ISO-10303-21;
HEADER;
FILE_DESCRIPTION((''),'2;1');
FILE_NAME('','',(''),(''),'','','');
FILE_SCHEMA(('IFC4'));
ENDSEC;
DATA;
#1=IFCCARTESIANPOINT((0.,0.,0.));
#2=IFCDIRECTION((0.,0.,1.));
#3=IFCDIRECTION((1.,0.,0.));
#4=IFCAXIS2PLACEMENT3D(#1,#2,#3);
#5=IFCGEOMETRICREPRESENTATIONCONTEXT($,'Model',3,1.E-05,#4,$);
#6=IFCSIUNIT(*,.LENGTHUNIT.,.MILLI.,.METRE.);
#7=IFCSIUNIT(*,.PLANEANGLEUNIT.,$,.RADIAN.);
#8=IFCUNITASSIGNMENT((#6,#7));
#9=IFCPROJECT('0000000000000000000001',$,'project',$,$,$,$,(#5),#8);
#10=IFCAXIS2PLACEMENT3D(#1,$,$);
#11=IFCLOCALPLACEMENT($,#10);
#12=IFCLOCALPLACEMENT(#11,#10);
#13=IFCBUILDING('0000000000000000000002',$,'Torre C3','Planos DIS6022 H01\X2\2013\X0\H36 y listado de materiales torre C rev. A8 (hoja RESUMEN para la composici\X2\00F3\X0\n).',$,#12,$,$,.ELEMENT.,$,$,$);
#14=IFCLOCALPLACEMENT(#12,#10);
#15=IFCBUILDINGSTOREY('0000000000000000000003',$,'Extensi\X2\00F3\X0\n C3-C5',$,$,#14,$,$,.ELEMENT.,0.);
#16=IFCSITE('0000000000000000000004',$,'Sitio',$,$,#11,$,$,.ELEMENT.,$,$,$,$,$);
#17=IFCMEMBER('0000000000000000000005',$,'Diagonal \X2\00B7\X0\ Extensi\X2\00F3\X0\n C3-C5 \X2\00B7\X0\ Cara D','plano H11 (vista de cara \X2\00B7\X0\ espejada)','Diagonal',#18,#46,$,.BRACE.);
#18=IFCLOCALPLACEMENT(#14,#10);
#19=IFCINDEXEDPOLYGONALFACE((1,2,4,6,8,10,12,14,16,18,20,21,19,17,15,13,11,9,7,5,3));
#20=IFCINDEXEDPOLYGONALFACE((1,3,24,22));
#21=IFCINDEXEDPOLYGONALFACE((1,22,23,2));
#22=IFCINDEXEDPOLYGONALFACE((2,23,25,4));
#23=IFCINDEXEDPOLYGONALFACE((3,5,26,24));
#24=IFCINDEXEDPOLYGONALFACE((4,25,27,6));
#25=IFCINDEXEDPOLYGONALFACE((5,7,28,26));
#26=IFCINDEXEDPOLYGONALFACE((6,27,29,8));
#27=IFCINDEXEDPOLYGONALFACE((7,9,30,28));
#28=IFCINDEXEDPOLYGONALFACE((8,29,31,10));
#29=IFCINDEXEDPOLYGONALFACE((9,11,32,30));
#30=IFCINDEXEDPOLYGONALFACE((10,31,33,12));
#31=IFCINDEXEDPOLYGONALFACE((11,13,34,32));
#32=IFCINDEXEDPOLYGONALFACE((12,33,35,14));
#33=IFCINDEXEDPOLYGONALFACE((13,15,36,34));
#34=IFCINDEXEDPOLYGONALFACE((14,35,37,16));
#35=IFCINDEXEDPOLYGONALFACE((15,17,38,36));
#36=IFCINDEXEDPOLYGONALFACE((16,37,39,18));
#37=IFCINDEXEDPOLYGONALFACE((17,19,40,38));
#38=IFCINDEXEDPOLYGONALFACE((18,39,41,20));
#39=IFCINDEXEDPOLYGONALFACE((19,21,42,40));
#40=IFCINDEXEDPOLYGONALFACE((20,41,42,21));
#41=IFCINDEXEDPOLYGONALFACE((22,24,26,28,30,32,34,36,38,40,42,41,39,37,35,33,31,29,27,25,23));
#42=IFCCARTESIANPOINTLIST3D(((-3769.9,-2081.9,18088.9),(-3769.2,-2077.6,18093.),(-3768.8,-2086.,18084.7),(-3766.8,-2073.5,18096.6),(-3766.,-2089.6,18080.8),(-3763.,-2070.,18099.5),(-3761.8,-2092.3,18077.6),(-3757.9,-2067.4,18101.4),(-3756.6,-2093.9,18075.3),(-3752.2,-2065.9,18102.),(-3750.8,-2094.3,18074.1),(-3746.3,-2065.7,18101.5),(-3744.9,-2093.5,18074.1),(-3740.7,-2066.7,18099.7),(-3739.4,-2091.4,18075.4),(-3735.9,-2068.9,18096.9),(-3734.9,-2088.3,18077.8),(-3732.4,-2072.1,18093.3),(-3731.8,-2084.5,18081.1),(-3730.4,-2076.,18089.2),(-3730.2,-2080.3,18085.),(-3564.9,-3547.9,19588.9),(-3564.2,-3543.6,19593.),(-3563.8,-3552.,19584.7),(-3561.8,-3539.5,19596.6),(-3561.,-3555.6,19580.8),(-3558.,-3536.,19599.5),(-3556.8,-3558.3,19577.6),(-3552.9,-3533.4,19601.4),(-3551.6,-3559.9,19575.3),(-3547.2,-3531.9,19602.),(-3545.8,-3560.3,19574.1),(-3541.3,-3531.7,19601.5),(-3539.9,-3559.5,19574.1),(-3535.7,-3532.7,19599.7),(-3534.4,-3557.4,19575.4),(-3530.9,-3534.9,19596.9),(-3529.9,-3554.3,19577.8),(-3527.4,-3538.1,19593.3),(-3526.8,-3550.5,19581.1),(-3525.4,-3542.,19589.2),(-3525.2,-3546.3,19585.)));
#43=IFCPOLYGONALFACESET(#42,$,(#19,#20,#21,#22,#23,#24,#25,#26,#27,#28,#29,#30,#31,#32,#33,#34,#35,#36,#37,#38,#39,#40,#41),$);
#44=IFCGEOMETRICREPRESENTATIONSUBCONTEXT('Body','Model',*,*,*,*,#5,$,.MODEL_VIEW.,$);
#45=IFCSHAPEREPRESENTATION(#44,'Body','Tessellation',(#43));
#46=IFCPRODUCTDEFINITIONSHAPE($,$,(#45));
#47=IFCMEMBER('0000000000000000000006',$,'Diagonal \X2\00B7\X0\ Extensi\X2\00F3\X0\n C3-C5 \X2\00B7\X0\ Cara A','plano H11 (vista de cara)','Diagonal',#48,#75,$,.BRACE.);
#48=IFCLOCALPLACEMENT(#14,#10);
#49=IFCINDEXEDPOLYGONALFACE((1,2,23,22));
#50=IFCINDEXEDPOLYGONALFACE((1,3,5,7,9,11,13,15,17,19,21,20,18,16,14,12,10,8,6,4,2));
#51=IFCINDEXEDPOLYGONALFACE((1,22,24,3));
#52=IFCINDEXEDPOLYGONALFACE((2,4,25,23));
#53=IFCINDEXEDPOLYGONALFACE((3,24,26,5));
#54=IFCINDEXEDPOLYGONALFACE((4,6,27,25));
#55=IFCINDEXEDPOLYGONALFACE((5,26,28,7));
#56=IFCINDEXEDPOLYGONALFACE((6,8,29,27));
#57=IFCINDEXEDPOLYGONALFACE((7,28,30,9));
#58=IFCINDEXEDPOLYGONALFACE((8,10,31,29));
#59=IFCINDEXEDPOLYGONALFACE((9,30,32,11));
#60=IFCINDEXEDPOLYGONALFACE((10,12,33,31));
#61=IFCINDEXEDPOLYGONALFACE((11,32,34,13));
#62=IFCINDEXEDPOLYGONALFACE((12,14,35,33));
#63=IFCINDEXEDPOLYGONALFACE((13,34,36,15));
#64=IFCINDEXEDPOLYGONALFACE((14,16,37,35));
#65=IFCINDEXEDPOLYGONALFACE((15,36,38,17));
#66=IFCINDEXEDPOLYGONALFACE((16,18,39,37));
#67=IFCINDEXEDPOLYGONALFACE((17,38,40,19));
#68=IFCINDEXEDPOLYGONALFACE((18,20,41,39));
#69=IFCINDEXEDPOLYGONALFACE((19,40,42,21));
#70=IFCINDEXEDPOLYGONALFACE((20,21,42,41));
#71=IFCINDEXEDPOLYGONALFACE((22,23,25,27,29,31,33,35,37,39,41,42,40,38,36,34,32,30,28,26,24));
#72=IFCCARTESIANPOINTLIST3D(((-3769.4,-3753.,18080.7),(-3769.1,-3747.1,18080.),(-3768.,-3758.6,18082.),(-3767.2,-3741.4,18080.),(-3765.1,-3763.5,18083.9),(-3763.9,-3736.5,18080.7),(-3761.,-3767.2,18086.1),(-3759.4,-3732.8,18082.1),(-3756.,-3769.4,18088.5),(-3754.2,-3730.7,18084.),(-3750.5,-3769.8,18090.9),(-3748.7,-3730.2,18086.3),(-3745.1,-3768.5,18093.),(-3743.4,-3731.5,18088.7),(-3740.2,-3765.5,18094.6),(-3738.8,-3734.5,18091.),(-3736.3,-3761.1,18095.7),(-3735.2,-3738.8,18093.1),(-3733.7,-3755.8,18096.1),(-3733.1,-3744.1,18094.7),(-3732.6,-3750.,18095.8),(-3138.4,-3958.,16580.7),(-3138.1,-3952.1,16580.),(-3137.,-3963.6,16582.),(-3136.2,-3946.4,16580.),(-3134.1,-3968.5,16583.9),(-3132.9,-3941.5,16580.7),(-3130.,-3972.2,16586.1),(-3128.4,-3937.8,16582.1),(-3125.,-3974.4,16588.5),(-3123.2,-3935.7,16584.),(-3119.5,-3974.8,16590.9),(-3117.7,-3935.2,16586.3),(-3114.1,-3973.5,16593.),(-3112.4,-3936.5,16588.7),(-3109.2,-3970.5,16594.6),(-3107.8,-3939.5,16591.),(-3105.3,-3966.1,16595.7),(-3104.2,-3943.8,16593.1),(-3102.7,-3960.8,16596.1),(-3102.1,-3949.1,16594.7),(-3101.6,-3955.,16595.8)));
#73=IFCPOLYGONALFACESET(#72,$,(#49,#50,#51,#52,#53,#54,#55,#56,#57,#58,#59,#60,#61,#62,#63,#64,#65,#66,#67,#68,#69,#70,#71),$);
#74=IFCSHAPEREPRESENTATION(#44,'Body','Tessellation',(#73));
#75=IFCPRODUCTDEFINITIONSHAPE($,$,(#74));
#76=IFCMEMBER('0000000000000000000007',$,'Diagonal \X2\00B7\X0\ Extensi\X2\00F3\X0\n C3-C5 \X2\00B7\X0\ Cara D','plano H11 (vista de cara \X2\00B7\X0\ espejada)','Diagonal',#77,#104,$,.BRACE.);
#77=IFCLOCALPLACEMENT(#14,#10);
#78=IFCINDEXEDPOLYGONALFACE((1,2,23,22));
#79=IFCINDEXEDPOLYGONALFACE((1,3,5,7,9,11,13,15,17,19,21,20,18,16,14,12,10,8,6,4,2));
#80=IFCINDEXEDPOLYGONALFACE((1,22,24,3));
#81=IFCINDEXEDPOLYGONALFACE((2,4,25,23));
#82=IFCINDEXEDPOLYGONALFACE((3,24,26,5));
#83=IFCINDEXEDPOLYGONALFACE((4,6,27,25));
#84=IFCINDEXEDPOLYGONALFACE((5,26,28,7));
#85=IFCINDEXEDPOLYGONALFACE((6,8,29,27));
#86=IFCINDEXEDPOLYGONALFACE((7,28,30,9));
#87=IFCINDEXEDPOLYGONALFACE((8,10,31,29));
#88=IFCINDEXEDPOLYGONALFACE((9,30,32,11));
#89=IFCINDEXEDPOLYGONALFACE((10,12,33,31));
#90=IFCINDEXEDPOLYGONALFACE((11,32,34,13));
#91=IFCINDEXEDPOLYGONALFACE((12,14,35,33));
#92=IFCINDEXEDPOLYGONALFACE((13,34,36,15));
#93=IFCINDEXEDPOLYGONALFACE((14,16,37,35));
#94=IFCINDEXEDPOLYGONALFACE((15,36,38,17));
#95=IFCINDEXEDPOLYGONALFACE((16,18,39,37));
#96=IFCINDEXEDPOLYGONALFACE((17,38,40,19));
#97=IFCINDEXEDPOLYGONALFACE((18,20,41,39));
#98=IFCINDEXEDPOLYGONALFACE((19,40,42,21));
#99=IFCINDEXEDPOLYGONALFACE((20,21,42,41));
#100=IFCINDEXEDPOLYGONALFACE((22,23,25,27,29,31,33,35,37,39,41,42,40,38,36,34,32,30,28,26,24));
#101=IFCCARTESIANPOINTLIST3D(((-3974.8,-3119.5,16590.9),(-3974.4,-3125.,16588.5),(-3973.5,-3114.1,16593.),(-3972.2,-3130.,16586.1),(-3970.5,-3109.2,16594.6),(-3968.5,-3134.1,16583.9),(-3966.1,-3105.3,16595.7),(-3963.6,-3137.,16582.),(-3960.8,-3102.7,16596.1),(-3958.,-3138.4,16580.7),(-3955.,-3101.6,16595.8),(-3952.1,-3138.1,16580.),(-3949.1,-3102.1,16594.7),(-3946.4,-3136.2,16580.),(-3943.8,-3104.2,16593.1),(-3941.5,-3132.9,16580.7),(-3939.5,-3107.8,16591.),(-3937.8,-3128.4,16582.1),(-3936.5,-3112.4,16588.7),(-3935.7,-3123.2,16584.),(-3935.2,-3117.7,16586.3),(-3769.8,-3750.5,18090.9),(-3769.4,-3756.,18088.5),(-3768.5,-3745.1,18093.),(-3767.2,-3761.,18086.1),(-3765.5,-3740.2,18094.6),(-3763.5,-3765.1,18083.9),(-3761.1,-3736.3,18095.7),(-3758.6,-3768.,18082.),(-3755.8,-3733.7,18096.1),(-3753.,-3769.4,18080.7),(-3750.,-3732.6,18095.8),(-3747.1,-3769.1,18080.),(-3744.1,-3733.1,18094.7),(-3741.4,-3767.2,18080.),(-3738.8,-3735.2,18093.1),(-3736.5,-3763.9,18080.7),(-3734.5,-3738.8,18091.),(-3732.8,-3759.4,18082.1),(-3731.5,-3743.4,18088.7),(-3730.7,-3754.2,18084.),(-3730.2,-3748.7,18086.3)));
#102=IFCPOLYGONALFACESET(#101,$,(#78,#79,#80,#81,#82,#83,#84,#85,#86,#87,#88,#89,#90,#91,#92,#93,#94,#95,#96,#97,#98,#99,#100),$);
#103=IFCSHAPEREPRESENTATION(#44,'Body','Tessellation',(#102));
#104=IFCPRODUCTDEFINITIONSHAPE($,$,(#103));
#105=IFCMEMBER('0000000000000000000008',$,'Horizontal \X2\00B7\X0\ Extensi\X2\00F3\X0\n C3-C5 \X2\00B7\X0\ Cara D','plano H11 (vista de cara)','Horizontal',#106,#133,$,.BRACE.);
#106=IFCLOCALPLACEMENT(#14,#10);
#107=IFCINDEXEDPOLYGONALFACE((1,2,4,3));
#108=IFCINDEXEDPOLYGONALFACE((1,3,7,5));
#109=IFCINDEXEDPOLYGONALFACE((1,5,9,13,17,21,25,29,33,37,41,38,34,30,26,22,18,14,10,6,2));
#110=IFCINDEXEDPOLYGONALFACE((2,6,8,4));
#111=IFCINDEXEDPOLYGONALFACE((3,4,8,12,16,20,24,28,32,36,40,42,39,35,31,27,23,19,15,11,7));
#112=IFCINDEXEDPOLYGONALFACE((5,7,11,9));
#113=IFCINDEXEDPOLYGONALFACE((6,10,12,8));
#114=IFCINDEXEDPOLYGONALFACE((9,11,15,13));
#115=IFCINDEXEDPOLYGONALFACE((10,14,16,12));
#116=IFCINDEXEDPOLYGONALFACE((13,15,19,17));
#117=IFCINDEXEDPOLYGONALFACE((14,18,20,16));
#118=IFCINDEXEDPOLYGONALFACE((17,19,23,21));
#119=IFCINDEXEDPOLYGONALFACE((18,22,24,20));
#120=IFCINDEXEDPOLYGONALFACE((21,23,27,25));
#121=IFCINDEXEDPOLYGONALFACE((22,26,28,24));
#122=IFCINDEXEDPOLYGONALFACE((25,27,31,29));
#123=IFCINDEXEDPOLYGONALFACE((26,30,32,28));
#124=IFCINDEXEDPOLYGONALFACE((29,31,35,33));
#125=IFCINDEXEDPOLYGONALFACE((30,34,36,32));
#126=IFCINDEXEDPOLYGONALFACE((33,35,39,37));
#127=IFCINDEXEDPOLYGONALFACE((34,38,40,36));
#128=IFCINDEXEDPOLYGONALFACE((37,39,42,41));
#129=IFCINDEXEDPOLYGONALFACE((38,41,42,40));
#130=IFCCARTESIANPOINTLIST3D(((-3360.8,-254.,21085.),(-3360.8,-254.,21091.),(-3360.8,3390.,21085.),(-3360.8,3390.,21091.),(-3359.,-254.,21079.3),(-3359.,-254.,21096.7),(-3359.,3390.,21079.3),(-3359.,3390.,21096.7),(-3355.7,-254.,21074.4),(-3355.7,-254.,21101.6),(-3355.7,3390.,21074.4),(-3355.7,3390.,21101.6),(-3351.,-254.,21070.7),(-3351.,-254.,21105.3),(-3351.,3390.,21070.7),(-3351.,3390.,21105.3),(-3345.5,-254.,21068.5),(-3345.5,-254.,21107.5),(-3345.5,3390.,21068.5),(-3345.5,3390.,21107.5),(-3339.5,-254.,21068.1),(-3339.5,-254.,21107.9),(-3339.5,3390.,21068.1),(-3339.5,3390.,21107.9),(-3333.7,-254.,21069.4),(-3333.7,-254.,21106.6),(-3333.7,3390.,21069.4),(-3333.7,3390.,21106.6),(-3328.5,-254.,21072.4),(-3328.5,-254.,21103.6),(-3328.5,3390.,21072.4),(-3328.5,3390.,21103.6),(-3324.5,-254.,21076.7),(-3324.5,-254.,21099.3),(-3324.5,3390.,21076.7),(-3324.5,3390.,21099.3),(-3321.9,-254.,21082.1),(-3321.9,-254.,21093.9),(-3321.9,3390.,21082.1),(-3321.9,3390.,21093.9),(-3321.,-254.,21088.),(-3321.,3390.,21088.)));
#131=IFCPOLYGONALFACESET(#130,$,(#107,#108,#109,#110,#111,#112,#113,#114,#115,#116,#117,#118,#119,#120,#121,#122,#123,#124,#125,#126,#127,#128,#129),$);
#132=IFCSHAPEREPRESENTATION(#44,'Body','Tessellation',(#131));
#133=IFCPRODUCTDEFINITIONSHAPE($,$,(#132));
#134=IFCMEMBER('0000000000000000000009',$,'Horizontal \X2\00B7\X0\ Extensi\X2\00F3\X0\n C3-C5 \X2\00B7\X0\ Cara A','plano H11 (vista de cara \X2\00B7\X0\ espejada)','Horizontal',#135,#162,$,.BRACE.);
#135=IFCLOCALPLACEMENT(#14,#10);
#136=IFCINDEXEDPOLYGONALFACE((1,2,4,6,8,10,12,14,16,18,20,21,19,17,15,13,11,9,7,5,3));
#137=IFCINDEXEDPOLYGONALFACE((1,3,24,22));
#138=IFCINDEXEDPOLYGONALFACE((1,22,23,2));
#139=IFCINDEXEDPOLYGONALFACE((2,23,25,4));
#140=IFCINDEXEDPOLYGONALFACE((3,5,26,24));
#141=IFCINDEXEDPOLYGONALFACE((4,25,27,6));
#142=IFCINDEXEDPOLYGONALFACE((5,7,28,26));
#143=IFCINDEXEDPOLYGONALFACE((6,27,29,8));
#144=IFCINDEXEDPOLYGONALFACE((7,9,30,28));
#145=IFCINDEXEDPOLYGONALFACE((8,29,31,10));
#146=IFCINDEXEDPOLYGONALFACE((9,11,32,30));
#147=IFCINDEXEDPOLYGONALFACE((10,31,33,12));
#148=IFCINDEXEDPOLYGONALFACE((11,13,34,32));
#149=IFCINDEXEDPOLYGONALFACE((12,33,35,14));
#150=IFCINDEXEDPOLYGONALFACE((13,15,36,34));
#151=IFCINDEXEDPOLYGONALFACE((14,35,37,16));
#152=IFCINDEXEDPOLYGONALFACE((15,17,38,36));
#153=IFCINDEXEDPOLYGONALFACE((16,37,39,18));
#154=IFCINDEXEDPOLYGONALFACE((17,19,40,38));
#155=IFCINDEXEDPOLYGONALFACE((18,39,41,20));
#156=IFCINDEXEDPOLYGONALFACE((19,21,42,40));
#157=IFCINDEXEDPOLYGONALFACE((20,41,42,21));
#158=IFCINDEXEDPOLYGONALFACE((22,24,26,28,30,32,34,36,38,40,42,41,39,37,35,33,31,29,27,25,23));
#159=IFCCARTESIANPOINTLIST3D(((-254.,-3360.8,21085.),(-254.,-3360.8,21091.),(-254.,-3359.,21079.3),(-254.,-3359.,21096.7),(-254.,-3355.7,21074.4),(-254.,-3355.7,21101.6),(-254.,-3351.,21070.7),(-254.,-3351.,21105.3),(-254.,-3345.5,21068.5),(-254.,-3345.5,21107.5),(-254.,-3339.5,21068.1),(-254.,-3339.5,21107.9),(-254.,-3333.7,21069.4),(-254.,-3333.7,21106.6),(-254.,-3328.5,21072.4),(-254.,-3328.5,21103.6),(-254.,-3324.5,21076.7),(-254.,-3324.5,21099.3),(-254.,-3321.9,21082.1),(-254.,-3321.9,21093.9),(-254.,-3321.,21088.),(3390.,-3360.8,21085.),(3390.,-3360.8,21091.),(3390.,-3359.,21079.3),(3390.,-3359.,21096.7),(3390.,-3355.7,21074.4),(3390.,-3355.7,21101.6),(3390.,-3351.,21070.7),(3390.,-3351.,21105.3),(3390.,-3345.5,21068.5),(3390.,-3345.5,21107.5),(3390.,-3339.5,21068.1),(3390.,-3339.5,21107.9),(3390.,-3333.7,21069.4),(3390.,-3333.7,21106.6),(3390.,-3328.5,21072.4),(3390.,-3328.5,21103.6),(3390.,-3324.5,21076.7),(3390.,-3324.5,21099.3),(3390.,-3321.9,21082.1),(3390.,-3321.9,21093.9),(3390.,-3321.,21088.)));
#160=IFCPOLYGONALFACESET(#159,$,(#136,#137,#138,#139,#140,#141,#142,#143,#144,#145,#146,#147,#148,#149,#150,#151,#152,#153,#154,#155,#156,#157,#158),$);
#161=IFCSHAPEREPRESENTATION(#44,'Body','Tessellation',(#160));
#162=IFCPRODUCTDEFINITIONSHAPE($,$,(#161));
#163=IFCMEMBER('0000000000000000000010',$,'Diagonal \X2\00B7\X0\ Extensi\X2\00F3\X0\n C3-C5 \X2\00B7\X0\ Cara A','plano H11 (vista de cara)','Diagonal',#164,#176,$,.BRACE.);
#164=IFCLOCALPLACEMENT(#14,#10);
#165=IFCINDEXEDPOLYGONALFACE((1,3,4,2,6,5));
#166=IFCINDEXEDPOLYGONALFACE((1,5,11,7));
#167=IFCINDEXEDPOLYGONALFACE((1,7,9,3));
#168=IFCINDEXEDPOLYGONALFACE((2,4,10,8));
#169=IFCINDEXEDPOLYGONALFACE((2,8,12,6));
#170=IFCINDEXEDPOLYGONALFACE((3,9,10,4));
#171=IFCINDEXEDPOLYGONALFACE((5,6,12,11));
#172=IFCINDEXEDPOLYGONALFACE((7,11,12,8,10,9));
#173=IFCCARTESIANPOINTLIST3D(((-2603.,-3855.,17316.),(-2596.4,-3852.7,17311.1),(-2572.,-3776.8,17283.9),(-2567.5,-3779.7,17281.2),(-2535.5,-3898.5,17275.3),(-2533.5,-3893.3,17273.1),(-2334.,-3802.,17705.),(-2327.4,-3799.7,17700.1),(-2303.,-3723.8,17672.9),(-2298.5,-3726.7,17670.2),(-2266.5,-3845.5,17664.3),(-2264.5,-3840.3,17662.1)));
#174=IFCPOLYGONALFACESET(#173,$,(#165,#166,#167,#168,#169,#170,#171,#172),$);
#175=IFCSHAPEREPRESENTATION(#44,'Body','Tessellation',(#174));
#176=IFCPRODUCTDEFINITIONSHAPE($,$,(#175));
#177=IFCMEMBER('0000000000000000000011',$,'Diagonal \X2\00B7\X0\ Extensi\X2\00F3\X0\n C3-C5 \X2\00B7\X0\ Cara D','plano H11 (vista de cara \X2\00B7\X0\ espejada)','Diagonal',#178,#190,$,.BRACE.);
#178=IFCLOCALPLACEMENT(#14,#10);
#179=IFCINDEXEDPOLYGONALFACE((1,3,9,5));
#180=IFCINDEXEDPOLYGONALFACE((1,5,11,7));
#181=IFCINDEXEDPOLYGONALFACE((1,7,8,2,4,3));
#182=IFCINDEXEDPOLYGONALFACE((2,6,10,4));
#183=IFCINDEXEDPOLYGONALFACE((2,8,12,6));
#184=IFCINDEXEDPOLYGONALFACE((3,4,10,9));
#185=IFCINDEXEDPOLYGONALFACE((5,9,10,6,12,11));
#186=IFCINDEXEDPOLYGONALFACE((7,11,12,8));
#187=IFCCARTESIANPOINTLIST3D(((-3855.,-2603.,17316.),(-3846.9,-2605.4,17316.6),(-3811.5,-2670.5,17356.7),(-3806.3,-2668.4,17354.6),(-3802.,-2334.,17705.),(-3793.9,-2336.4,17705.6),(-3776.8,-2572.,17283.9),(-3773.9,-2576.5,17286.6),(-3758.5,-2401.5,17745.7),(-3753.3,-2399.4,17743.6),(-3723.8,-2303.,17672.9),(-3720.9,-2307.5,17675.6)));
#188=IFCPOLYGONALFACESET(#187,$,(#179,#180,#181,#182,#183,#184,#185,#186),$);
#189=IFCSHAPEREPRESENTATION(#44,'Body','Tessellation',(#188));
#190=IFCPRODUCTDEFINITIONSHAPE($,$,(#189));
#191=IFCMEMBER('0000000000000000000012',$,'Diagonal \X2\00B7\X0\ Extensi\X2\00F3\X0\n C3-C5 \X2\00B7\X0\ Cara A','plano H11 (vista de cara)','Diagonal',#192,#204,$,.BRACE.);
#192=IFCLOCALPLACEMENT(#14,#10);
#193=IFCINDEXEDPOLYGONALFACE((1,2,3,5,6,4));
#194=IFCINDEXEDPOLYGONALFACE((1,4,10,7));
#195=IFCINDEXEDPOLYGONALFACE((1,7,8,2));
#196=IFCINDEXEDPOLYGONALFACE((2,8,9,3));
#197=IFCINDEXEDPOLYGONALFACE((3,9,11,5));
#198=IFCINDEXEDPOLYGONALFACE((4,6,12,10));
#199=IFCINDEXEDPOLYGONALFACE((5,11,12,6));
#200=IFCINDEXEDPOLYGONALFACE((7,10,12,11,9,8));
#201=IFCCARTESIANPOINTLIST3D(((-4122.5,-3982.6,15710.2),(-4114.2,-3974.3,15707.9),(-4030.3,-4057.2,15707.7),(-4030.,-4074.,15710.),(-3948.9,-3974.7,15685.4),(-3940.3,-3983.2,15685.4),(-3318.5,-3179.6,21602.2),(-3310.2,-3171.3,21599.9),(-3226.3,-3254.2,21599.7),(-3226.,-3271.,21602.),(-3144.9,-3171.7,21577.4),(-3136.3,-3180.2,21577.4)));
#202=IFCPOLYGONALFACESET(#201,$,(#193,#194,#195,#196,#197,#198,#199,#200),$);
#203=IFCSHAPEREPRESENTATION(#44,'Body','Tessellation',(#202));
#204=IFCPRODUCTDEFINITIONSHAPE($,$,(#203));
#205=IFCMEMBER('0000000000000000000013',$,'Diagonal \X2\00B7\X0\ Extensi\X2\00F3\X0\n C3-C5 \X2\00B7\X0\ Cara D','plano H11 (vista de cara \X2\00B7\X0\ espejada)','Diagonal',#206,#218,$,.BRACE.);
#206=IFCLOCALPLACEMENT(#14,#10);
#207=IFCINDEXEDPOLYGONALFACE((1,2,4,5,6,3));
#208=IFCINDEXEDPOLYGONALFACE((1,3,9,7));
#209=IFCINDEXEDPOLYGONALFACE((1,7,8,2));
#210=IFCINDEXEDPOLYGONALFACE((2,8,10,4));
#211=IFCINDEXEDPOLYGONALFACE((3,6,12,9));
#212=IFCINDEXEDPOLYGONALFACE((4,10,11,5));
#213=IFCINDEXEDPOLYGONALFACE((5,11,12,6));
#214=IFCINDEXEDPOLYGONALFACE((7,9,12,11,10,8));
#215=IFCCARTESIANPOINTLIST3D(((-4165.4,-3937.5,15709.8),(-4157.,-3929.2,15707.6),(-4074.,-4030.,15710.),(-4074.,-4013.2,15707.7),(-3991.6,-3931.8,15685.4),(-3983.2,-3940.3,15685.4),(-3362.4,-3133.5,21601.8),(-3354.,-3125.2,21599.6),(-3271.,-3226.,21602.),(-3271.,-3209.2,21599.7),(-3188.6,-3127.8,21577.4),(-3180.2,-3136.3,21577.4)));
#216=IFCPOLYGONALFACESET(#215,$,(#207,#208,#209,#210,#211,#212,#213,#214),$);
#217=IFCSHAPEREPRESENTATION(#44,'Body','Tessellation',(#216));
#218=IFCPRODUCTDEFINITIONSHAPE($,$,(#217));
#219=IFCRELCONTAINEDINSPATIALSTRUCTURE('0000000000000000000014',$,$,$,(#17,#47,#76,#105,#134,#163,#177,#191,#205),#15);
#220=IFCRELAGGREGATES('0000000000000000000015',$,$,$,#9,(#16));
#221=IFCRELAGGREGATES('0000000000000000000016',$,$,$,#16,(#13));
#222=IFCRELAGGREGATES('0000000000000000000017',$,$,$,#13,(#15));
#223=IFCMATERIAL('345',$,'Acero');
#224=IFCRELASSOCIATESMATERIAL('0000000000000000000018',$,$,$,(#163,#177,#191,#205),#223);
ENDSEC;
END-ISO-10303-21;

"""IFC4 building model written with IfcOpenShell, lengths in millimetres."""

from ifc_helpers import new_model, si_unit, frame, frame_2d, origin, origin_with_axes, place, context, subcontext, project, spatial, circle, l_section, extrude, material, element, save


model = new_model("IFC4")

# Units and contexts
model_context = context("Model", 3, precision=1e-05, world=origin_with_axes())
body_context = subcontext(model_context, "Body", "Model", "MODEL_VIEW")
ifc_project = project(units=[si_unit("LENGTHUNIT", "METRE", prefix="MILLI"), si_unit("PLANEANGLEUNIT", "RADIAN")], contexts=[model_context])

# Site, building, storey
site_placement = place(None, origin())
site = spatial("IfcSite", under=ifc_project, at=site_placement, Name="Sitio", CompositionType="ELEMENT")
building_placement = place(site_placement, origin())
building = spatial("IfcBuilding", under=site, at=building_placement, Name="Torre C3", Description="Planos DIS6022 H01–H36 y listado de materiales torre C rev. A8 (hoja RESUMEN para la composición).", CompositionType="ELEMENT")
storey_placement = place(building_placement, origin())
storey = spatial("IfcBuildingStorey", under=building, at=storey_placement, Name="Extensión C3-C5", CompositionType="ELEMENT", Elevation=0.0)

# Members
ifc_material_1 = material(Name="345", Category="Acero")
for number, where, z_axis, x_axis, name in (
    (1, (-3545.0, -3546.0, 19588.0), (-0.097276, 0.69564, -0.711774), (0.880677, 0.39331, 0.264036), "Diagonal · Extensión C3-C5 · Cara D"),
):
    element("IfcMember", number, at=place(storey_placement, frame(where, z_axis=z_axis, x_axis=x_axis)), inside=storey, Name=name, Description="plano H11 (vista de cara · espejada)", ObjectType="Diagonal", PredefinedType="BRACE", context=body_context, shape_type="SweptSolid", body=[
        extrude(circle(Radius=20.0), None, (0.0, 0.0, 1.0), 2107.4),
    ])
for number, where, z_axis, x_axis, name, description in (
    (2, (-3751.0, -3750.0, 18088.0), (0.384714, -0.124986, -0.914535), (0.61109, 0.777051, 0.150868), "Diagonal · Extensión C3-C5 · Cara A", "plano H11 (vista de cara)"),
    (3, (-3750.0, -3751.0, 18088.0), (-0.124986, 0.384714, -0.914535), (0.777051, 0.61109, 0.150868), "Diagonal · Extensión C3-C5 · Cara D", "plano H11 (vista de cara · espejada)"),
):
    element("IfcMember", number, at=place(storey_placement, frame(where, z_axis=z_axis, x_axis=x_axis)), inside=storey, Name=name, Description=description, ObjectType="Diagonal", PredefinedType="BRACE", context=body_context, shape_type="SweptSolid", body=[
        extrude(circle(Radius=20.0), None, (0.0, 0.0, 1.0), 1640.2),
    ])
for number, where, z_axis, x_axis, name, description in (
    (4, (-3341.0, -254.0, 21088.0), (0.0, 1.0, 0.0), (1.0, 0.0, 0.0), "Horizontal · Extensión C3-C5 · Cara D", "plano H11 (vista de cara)"),
    (5, (-254.0, -3341.0, 21088.0), (1.0, 0.0, 0.0), (0.0, 1.0, 0.0), "Horizontal · Extensión C3-C5 · Cara A", "plano H11 (vista de cara · espejada)"),
):
    element("IfcMember", number, at=place(storey_placement, frame(where, z_axis=z_axis, x_axis=x_axis)), inside=storey, Name=name, Description=description, ObjectType="Horizontal", PredefinedType="BRACE", context=body_context, shape_type="SweptSolid", body=[
        extrude(circle(Radius=20.0), None, (0.0, 0.0, 1.0), 3644.0),
    ])
for number, where, z_axis, x_axis, name, description in (
    (6, (-2334.0, -3802.0, 17705.0), (-0.565232, -0.111365, -0.81738), (0.344616, 0.868367, -0.35662), "Diagonal · Extensión C3-C5 · Cara A", "plano H11 (vista de cara)"),
    (7, (-3802.0, -2334.0, 17705.0), (-0.111365, -0.565232, -0.81738), (0.868367, 0.344616, -0.35662), "Diagonal · Extensión C3-C5 · Cara D", "plano H11 (vista de cara · espejada)"),
):
    element("IfcMember", number, at=place(storey_placement, frame(where, z_axis=z_axis, x_axis=x_axis)), inside=storey, material=ifc_material_1, Name=name, Description=description, ObjectType="Diagonal", PredefinedType="BRACE", context=body_context, shape_type="SweptSolid", body=[
        extrude(l_section(Depth=90.0, Width=90.0, Thickness=6.0, at=frame_2d((45.0, 45.0))), None, (0.0, 0.0, 1.0), 475.9),
    ])
for number, where, z_axis, x_axis, name, description in (
    (8, (-4030.0, -4074.0, 15710.0), (0.133987, 0.133821, 0.981906), (0.689893, 0.698705, -0.189364), "Diagonal · Extensión C3-C5 · Cara A", "plano H11 (vista de cara)"),
    (9, (-4074.0, -4030.0, 15710.0), (0.133821, 0.133987, 0.981906), (0.698705, 0.689893, -0.189364), "Diagonal · Extensión C3-C5 · Cara D", "plano H11 (vista de cara · espejada)"),
):
    element("IfcMember", number, at=place(storey_placement, frame(where, z_axis=z_axis, x_axis=x_axis)), inside=storey, material=ifc_material_1, Name=name, Description=description, ObjectType="Diagonal", PredefinedType="BRACE", context=body_context, shape_type="SweptSolid", body=[
        extrude(l_section(Depth=130.0, Width=130.0, Thickness=12.0, at=frame_2d((65.0, 65.0))), None, (0.0, 0.0, 1.0), 6000.6),
    ])

save(model, "model.ifc")
